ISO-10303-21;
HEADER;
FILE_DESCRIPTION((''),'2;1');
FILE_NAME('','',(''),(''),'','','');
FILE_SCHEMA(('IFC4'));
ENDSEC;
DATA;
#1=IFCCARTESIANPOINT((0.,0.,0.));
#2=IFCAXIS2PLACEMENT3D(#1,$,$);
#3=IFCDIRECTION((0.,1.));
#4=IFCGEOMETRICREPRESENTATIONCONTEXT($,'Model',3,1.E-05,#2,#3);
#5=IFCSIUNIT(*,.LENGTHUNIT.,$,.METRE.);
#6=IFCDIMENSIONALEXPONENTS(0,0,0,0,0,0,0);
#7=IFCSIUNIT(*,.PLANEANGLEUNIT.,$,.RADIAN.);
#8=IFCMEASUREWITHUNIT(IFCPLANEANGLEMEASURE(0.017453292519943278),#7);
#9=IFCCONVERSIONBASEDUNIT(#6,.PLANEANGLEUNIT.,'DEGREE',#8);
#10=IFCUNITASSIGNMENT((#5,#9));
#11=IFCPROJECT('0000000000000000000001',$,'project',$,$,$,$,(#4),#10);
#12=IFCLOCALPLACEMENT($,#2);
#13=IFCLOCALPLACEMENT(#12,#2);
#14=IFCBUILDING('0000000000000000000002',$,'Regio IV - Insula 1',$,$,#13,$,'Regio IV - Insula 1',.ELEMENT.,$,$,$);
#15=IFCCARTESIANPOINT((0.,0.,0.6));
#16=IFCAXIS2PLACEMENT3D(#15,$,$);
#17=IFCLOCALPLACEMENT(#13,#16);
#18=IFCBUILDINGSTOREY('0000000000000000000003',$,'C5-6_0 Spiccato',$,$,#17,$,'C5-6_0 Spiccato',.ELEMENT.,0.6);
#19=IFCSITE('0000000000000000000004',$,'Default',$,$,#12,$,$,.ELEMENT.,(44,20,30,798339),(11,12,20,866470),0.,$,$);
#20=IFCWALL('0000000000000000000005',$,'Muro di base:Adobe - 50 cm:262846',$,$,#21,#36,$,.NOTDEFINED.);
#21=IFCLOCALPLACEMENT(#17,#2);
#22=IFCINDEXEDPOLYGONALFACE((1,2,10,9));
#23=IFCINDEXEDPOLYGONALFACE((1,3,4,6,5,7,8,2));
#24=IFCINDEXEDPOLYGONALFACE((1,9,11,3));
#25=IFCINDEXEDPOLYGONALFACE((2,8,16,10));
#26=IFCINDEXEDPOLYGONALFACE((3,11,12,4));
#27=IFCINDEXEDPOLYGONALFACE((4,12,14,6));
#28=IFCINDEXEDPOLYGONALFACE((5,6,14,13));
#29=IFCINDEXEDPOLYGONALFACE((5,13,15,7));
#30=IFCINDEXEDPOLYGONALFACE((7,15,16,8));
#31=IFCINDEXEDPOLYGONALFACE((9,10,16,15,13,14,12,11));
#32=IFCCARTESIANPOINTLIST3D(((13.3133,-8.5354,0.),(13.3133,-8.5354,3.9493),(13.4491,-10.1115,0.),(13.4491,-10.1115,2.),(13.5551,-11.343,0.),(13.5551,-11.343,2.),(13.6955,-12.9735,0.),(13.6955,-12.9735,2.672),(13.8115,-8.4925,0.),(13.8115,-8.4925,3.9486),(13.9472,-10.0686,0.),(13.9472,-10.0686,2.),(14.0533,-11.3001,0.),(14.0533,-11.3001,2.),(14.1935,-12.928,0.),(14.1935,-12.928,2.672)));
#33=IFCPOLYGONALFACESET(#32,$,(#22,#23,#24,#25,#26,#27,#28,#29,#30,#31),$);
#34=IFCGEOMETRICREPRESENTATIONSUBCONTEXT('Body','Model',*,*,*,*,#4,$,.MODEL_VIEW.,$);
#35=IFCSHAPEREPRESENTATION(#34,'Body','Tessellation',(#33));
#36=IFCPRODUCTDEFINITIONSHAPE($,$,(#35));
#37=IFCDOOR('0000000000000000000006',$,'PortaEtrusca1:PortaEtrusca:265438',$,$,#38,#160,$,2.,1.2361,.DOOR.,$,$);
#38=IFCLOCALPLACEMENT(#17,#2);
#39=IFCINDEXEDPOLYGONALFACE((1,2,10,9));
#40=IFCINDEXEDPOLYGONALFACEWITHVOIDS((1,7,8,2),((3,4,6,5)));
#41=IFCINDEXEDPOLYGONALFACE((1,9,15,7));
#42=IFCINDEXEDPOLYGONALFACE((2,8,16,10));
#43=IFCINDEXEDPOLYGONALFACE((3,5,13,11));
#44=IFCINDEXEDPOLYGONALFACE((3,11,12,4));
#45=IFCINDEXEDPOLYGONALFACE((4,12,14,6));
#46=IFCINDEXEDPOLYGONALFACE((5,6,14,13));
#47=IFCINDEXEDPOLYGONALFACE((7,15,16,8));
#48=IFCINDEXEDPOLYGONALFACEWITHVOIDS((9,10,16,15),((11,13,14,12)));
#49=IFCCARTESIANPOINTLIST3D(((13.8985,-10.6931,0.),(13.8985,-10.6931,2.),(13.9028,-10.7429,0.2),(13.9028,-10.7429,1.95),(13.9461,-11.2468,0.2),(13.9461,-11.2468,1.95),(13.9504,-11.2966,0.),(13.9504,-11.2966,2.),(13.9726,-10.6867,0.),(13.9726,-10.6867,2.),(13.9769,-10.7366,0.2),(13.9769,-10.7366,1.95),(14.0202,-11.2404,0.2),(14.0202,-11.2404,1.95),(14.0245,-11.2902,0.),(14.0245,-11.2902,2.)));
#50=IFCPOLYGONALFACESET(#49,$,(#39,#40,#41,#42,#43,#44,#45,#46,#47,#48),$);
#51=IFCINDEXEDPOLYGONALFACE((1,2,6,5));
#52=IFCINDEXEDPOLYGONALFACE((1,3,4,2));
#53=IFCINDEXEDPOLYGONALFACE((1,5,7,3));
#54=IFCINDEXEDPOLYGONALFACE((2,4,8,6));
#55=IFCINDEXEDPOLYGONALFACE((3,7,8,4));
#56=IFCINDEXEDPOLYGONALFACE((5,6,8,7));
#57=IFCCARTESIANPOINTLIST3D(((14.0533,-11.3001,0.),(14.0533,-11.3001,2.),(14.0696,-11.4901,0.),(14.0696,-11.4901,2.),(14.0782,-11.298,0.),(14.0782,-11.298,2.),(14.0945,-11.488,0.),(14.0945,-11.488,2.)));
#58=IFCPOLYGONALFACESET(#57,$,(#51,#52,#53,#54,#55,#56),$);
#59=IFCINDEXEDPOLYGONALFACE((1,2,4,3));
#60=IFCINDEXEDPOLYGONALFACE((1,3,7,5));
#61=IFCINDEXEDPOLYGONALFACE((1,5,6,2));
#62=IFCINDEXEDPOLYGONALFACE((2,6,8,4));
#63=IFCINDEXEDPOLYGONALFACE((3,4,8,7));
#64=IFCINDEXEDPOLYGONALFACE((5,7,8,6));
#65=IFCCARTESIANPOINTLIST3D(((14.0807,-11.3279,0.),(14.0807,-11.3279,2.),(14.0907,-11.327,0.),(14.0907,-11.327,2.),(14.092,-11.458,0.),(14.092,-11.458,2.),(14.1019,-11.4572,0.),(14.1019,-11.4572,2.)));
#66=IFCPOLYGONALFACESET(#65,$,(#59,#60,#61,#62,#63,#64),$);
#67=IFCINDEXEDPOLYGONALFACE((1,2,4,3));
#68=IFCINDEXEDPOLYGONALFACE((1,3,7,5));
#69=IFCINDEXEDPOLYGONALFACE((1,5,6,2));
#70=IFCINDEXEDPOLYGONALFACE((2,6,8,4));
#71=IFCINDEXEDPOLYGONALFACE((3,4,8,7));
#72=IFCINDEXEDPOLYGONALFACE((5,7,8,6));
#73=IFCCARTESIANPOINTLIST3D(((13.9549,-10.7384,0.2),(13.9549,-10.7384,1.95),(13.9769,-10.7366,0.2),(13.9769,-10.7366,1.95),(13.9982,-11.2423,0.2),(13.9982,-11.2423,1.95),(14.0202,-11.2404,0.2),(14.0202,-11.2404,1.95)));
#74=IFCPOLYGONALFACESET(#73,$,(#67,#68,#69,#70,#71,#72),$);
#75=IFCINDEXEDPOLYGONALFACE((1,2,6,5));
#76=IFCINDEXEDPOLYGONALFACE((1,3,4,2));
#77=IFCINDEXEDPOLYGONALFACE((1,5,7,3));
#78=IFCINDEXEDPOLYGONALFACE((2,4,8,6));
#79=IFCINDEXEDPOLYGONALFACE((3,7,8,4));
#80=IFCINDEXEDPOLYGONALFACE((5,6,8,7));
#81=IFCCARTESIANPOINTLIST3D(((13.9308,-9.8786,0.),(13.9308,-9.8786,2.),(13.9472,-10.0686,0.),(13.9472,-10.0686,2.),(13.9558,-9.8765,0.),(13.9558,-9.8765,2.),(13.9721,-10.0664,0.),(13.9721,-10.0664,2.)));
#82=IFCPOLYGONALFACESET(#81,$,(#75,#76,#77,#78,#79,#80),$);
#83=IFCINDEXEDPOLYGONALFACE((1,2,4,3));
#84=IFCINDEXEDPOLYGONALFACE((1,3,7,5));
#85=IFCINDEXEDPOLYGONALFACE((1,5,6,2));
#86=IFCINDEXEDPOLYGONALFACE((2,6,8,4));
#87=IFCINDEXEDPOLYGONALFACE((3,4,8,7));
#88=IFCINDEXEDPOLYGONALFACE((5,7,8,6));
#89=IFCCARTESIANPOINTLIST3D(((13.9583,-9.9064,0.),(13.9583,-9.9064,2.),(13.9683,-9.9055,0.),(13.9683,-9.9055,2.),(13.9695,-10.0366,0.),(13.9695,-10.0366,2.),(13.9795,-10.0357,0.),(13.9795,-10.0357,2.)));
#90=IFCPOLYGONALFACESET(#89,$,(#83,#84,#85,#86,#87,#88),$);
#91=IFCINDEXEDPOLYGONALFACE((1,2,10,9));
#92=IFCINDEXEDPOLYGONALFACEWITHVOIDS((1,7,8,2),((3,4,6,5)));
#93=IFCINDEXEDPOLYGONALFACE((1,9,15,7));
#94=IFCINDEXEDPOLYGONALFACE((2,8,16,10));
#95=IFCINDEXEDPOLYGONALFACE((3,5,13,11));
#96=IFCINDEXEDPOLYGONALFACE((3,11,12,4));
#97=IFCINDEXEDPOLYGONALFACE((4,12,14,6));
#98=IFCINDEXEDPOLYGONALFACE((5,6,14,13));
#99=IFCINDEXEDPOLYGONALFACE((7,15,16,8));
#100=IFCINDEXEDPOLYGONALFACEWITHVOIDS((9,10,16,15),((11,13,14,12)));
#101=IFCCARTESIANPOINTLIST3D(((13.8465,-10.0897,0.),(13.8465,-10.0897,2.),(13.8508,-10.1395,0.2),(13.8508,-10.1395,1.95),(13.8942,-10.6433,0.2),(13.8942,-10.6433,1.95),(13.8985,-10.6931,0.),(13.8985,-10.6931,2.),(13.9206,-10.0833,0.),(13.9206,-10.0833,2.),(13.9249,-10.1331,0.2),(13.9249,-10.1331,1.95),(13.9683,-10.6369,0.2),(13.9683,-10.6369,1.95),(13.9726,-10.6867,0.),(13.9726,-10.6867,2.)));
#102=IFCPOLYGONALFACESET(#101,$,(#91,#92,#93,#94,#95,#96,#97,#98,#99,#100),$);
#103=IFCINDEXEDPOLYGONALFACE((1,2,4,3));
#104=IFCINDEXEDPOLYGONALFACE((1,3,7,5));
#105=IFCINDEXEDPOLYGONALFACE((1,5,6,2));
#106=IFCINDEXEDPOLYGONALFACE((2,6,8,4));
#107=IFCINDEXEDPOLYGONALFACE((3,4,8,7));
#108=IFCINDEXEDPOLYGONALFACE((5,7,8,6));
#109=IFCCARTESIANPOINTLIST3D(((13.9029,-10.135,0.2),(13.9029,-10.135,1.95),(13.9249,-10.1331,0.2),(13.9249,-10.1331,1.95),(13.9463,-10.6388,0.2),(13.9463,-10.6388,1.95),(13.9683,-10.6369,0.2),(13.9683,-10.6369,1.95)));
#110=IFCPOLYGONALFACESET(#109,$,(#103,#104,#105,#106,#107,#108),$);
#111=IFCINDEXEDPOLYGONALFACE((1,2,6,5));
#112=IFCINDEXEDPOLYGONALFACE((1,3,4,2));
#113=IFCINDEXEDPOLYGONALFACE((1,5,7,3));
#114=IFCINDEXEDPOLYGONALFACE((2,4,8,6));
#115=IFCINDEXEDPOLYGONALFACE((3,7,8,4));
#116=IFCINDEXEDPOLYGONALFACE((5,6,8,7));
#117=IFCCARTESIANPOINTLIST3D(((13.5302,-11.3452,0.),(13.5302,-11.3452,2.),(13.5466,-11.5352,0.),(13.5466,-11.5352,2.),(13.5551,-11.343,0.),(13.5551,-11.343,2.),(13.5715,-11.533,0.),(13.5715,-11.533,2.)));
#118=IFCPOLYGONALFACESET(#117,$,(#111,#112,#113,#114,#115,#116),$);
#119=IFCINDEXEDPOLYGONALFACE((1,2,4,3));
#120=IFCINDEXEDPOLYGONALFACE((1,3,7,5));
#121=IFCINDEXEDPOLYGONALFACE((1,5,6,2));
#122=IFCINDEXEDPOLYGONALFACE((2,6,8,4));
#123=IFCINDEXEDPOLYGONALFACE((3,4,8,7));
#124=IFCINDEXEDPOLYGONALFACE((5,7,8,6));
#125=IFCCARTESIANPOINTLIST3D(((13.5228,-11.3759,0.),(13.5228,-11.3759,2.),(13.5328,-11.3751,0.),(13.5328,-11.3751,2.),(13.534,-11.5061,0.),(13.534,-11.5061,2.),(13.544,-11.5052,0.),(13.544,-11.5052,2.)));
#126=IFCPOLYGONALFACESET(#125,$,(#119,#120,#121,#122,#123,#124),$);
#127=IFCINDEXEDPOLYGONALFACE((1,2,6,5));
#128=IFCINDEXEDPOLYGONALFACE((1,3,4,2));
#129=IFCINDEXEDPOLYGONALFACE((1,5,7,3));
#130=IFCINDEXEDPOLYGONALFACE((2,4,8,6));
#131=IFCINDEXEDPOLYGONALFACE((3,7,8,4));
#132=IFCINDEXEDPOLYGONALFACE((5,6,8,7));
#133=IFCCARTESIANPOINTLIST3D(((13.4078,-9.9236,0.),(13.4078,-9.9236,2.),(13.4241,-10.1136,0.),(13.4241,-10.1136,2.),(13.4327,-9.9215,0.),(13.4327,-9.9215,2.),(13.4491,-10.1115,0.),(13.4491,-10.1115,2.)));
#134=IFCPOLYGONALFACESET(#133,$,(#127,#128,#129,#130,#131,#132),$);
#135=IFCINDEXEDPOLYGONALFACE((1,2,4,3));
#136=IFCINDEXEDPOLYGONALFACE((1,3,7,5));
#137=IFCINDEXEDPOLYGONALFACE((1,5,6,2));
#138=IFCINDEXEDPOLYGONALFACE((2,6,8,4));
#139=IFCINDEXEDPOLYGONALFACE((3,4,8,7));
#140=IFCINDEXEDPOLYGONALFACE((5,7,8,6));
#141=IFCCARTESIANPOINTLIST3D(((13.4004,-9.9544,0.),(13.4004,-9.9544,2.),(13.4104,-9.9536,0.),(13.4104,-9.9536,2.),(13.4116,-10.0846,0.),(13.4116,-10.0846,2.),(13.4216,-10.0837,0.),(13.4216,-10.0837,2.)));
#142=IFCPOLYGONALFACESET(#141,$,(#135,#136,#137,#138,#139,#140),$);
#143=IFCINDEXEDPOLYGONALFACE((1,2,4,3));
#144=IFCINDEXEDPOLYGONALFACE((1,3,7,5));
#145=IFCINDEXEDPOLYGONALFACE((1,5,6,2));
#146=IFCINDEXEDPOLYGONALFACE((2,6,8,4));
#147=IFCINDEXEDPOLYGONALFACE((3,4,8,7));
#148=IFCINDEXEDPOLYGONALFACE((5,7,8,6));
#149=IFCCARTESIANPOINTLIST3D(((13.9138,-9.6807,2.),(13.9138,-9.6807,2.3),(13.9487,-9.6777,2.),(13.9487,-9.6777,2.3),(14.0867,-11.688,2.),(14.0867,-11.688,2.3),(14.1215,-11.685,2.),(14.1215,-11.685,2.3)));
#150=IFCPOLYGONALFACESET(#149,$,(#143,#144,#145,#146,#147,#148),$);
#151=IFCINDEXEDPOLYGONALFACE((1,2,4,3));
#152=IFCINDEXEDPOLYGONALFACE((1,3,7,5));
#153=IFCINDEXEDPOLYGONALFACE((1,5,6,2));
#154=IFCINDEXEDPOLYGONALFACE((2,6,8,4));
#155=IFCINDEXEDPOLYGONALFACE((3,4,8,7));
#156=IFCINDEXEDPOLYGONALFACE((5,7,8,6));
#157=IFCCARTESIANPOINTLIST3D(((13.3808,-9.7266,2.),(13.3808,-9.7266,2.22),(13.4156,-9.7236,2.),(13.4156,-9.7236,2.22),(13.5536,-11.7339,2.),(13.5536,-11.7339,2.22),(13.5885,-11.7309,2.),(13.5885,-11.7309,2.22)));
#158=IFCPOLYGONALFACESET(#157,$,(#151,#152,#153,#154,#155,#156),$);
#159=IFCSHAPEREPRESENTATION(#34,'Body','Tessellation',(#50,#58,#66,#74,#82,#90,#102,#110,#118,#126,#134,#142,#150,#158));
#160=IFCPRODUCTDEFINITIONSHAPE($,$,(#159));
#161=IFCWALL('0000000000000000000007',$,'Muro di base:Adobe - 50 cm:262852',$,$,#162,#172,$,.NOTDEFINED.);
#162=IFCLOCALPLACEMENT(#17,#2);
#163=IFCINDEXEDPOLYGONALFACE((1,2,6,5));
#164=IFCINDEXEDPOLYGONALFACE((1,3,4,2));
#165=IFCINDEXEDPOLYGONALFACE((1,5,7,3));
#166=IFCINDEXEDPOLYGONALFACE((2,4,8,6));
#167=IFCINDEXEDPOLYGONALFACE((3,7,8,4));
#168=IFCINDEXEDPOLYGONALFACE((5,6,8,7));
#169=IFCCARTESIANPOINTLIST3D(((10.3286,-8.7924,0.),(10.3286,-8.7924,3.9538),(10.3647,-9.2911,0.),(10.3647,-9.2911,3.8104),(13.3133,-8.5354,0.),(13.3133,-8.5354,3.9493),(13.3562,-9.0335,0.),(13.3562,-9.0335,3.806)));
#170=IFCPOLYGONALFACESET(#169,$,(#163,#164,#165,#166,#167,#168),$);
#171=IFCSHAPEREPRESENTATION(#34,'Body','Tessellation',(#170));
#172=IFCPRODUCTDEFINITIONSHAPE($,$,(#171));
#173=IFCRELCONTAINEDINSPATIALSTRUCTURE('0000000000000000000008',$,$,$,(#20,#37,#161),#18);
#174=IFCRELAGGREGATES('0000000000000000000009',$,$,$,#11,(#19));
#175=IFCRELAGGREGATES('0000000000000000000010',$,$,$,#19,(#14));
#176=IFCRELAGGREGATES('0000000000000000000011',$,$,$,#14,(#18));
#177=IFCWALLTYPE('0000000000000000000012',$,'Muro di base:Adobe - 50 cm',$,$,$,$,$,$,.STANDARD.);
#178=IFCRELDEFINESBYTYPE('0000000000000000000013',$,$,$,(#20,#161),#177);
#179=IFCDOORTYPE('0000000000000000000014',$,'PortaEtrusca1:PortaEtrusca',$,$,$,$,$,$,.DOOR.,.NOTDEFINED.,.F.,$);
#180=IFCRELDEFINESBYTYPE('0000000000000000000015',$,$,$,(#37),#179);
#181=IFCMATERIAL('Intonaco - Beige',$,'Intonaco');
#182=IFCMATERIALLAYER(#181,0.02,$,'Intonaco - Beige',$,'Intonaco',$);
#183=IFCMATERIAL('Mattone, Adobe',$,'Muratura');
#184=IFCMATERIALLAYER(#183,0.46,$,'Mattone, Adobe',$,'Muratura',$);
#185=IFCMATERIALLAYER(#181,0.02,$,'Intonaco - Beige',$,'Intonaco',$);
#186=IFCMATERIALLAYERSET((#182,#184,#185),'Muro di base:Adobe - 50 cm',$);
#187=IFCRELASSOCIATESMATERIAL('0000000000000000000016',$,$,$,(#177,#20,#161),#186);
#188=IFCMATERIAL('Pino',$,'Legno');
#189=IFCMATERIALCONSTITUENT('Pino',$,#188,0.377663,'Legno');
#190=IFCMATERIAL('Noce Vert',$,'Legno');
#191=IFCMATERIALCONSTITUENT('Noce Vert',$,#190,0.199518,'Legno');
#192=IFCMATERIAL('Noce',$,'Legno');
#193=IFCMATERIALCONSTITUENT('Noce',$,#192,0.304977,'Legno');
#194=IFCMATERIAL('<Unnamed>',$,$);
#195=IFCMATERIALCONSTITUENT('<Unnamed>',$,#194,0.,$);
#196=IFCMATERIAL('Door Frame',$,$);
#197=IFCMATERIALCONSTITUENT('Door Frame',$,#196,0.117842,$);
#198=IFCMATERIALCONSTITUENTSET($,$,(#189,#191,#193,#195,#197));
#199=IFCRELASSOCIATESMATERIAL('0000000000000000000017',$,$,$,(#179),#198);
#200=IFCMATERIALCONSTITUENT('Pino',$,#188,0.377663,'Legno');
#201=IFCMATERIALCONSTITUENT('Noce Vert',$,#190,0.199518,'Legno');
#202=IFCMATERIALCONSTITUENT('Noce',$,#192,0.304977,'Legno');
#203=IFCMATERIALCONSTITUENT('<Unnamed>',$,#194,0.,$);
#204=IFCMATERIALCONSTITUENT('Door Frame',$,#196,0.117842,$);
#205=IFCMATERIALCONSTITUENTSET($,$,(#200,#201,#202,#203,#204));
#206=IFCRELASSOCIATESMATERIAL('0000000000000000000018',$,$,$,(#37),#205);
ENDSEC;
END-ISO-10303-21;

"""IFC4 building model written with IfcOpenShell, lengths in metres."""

from ifc_helpers import new_model, entity, si_unit, converted_unit, direction, frame, frame_2d, origin, origin_2d_with_axis, place, context, subcontext, project, spatial, polyline, rectangle, outline, extrude, clip, bounded_halfspace, source, transform, mapped, material, layer, layer_set, layer_usage, constituent, constituent_set, type_object, type_shapes, element, fill, save


model = new_model("IFC4")

# Units and contexts
model_context = context("Model", 3, precision=1e-05, world=origin(), true_north=direction((0.0, 1.0)))
body_context = subcontext(model_context, "Body", "Model", "MODEL_VIEW")
ifc_project = project(units=[si_unit("LENGTHUNIT", "METRE"), converted_unit("PLANEANGLEUNIT", "DEGREE", entity("IfcPlaneAngleMeasure", 0.017453292519943278), si_unit("PLANEANGLEUNIT", "RADIAN"), dimensions=[0, 0, 0, 0, 0, 0, 0])], contexts=[model_context])

# Site, building, storey
site_placement = place(None, origin())
site = spatial("IfcSite", under=ifc_project, at=site_placement, Name="Default", CompositionType="ELEMENT", RefLatitude=(44, 20, 30, 798339), RefLongitude=(11, 12, 20, 866470), RefElevation=0.0)
building_placement = place(site_placement, origin())
building = spatial("IfcBuilding", under=site, at=building_placement, Name="Regio IV - Insula 1", LongName="Regio IV - Insula 1", CompositionType="ELEMENT")
storey_placement = place(building_placement, frame((0.0, 0.0, 0.6)))
storey = spatial("IfcBuildingStorey", under=building, at=storey_placement, Name="C5-6_0 Spiccato", LongName="C5-6_0 Spiccato", CompositionType="ELEMENT", Elevation=0.6)

# Shared definitions
ifc_material_1 = material(Name="Intonaco - Beige", Category="Intonaco")
ifc_material_2 = material(Name="Mattone, Adobe", Category="Muratura")
ifc_layer_1 = layer(ifc_material_1, 0.02, Name="Intonaco - Beige", Category="Intonaco")
ifc_layer_2 = layer(ifc_material_2, 0.46, Name="Mattone, Adobe", Category="Muratura")
ifc_layer_3 = layer(ifc_material_1, 0.02, Name="Intonaco - Beige", Category="Intonaco")
ifc_layer_set_1 = layer_set([ifc_layer_1, ifc_layer_2, ifc_layer_3], Name="Muro di base:Adobe - 50 cm")
wall_type_1 = type_object("IfcWallType", Name="Muro di base:Adobe - 50 cm", PredefinedType="STANDARD", material=ifc_layer_set_1)

# Shared definitions
ifc_material_3 = material(Name="Pino", Category="Legno")
ifc_material_4 = material(Name="Noce Vert", Category="Legno")
ifc_material_5 = material(Name="Noce", Category="Legno")
ifc_material_6 = material(Name="<Unnamed>")
ifc_material_7 = material(Name="Door Frame")
ifc_constituent_1 = constituent(ifc_material_3, Name="Pino", Category="Legno", fraction=0.377663)
ifc_constituent_2 = constituent(ifc_material_4, Name="Noce Vert", Category="Legno", fraction=0.199518)
ifc_constituent_3 = constituent(ifc_material_5, Name="Noce", Category="Legno", fraction=0.304977)
ifc_constituent_4 = constituent(ifc_material_6, Name="<Unnamed>", fraction=0.0)
ifc_constituent_5 = constituent(ifc_material_7, Name="Door Frame", fraction=0.117842)
ifc_constituent_set_1 = constituent_set(constituents=[ifc_constituent_1, ifc_constituent_2, ifc_constituent_3, ifc_constituent_4, ifc_constituent_5])
door_type = type_object("IfcDoorType", Name="PortaEtrusca1:PortaEtrusca", OperationType="NOTDEFINED", ParameterTakesPrecedence=False, PredefinedType="DOOR", material=ifc_constituent_set_1)
shared_shape = source(origin(), body_context, "Body", "SweptSolid", [
    extrude(outline(polyline([(-1.0, -0.3028), (1.0, -0.3028), (1.0, 0.3028), (-1.0, 0.3028), (-1.0, -0.3028)]), holes=[polyline([(-0.95, 0.2528), (0.8, 0.2528), (0.8, -0.2528), (-0.95, -0.2528), (-0.95, 0.2528)])]), frame((0.3152, 0.0278, 1.0), z_axis=(0.0, 1.0, 0.0), x_axis=(0.0, 0.0, -1.0)), (0.0, 0.0, 1.0), 0.0744),
    extrude(rectangle(XDim=0.025, YDim=0.1907, at=frame_2d((0.0, 0.0), x_axis=(1.0, 0.0))), frame((-0.0953, -0.0125, 0.0), z_axis=(0.0, 0.0, 1.0), x_axis=(0.0, 1.0, 0.0)), (0.0, 0.0, 1.0), 2.0),
    extrude(rectangle(XDim=0.01, YDim=0.1306, at=frame_2d((0.0, 0.0), x_axis=(1.0, 0.0))), frame((-0.0953, -0.03, 0.0), z_axis=(0.0, 0.0, 1.0), x_axis=(0.0, 1.0, 0.0)), (0.0, 0.0, 1.0), 2.0),
    extrude(rectangle(XDim=0.0221, YDim=0.5057, at=frame_2d((0.0, 0.0), x_axis=(1.0, 0.0))), frame((0.3152, 0.0388, 0.2), z_axis=(0.0, 0.0, 1.0), x_axis=(0.0, 1.0, 0.0)), (0.0, 0.0, 1.0), 1.75),
    extrude(rectangle(XDim=0.025, YDim=0.1907, at=frame_2d((0.0, 0.0), x_axis=(1.0, 0.0))), frame((1.3314, -0.0125, 0.0), z_axis=(0.0, 0.0, 1.0), x_axis=(0.0, 1.0, 0.0)), (0.0, 0.0, 1.0), 2.0),
    extrude(rectangle(XDim=0.01, YDim=0.1306, at=frame_2d((0.0, 0.0), x_axis=(1.0, 0.0))), frame((1.3314, -0.03, 0.0), z_axis=(0.0, 0.0, 1.0), x_axis=(0.0, 1.0, 0.0)), (0.0, 0.0, 1.0), 2.0),
    extrude(outline(polyline([(-0.3028, -1.0), (0.3028, -1.0), (0.3028, 1.0), (-0.3028, 1.0), (-0.3028, -1.0)]), holes=[polyline([(0.2528, -0.95), (-0.2528, -0.95), (-0.2528, 0.8), (0.2528, 0.8), (0.2528, -0.95)])]), frame((0.9209, 0.0278, 1.0), z_axis=(0.0, 1.0, 0.0), x_axis=(1.0, 0.0, 0.0)), (0.0, 0.0, 1.0), 0.0744),
    extrude(rectangle(XDim=0.0221, YDim=0.5057, at=frame_2d((0.0, 0.0), x_axis=(1.0, 0.0))), frame((0.9209, 0.0388, 0.2), z_axis=(0.0, 0.0, 1.0), x_axis=(0.0, 1.0, 0.0)), (0.0, 0.0, 1.0), 1.75),
    extrude(rectangle(XDim=0.025, YDim=0.1907, at=frame_2d((0.0, 0.0), x_axis=(1.0, 0.0))), frame((-0.0953, 0.5125, 0.0), z_axis=(0.0, 0.0, 1.0), x_axis=(0.0, -1.0, 0.0)), (0.0, 0.0, 1.0), 2.0),
    extrude(rectangle(XDim=0.01, YDim=0.1306, at=frame_2d((0.0, 0.0), x_axis=(1.0, 0.0))), frame((-0.0953, 0.53, 0.0), z_axis=(0.0, 0.0, 1.0), x_axis=(0.0, -1.0, 0.0)), (0.0, 0.0, 1.0), 2.0),
    extrude(rectangle(XDim=0.025, YDim=0.1907, at=frame_2d((0.0, 0.0), x_axis=(1.0, 0.0))), frame((1.3314, 0.5125, 0.0), z_axis=(0.0, 0.0, 1.0), x_axis=(0.0, -1.0, 0.0)), (0.0, 0.0, 1.0), 2.0),
    extrude(rectangle(XDim=0.01, YDim=0.1306, at=frame_2d((0.0, 0.0), x_axis=(1.0, 0.0))), frame((1.3314, 0.53, 0.0), z_axis=(0.0, 0.0, 1.0), x_axis=(0.0, -1.0, 0.0)), (0.0, 0.0, 1.0), 2.0),
    extrude(rectangle(XDim=0.035, YDim=2.0147, at=origin_2d_with_axis()), frame((0.618, -0.0175, 2.0), z_axis=(0.0, 0.0, 1.0), x_axis=(0.0, 1.0, 0.0)), (0.0, 0.0, 1.0), 0.3),
    extrude(rectangle(XDim=0.035, YDim=2.0147, at=origin_2d_with_axis()), frame((0.618, 0.5175, 2.0), z_axis=(0.0, 0.0, 1.0), x_axis=(0.0, -1.0, 0.0)), (0.0, 0.0, 1.0), 0.22),
])
type_shapes(door_type, [shared_shape])

# Wall, opening, door
ifc_layer_usage_1 = layer_usage(ifc_layer_set_1, "AXIS2", "NEGATIVE", 0.25)
wall_1_placement = place(storey_placement, frame((13.9446, -12.952, 0.0), z_axis=(0.0, 0.0, 1.0), x_axis=(-0.085801, 0.996312, 0.0)))
wall_1 = element("IfcWall", 1, at=wall_1_placement, inside=storey, type_object=wall_type_1, material=ifc_layer_usage_1, Name="Muro di base:Adobe - 50 cm:262846", PredefinedType="NOTDEFINED", context=body_context, shape_type="Clipping", body=[
    clip(extrude(outline(polyline([(0.0026, -0.25), (4.4545, -0.25), (4.4545, 0.25), (3.9545, 0.25), (0.0, 0.25), (0.0026, -0.25)])), origin(), (0.0, 0.0, 1.0), 3.9493), bounded_halfspace(frame((0.0026, -0.25, 2.672), z_axis=(-0.275634, -0.001422, 0.961262), x_axis=(0.00516, -0.999987, 0.0)), False, frame((0.0026, -0.25, 2.672)), polyline([(0.0, 0.0), (4.452, 0.0), (4.452, 0.5), (3.952, 0.5), (-0.0026, 0.5), (0.0, 0.0)]))),
])
opening_1_placement = place(wall_1_placement, frame((1.6365, -0.25, 0.0)))
opening_1 = element("IfcOpeningElement", 2, at=opening_1_placement, cuts=wall_1, PredefinedType="OPENING", context=body_context, shape_type="SweptSolid", body=[
    extrude(rectangle(XDim=2.0, YDim=1.2361, at=frame_2d((1.0, 0.618), x_axis=(1.0, 0.0))), frame((0.0, 0.0, 0.0), z_axis=(0.0, 1.0, 0.0), x_axis=(0.0, 0.0, 1.0)), (0.0, 0.0, 1.0), 0.5),
])
ifc_constituent_6 = constituent(ifc_material_3, Name="Pino", Category="Legno", fraction=0.377663)
ifc_constituent_7 = constituent(ifc_material_4, Name="Noce Vert", Category="Legno", fraction=0.199518)
ifc_constituent_8 = constituent(ifc_material_5, Name="Noce", Category="Legno", fraction=0.304977)
ifc_constituent_9 = constituent(ifc_material_6, Name="<Unnamed>", fraction=0.0)
ifc_constituent_10 = constituent(ifc_material_7, Name="Door Frame", fraction=0.117842)
ifc_constituent_set_2 = constituent_set(constituents=[ifc_constituent_6, ifc_constituent_7, ifc_constituent_8, ifc_constituent_9, ifc_constituent_10])
door_1_placement = place(opening_1_placement, origin())
door_1 = element("IfcDoor", 3, at=door_1_placement, inside=storey, type_object=door_type, material=ifc_constituent_set_2, Name="PortaEtrusca1:PortaEtrusca:265438", OverallHeight=2.0, OverallWidth=1.2361, PredefinedType="DOOR", context=body_context, shape_type="MappedRepresentation", body=[
    mapped(shared_shape, transform((0.0, 0.0, 0.0), scale=1.0)),
])
fill(opening_1, door_1)

# Wall
ifc_layer_usage_2 = layer_usage(ifc_layer_set_1, "AXIS2", "NEGATIVE", 0.25)
wall_2_placement = place(storey_placement, frame((13.3348, -8.7844, 0.0), z_axis=(0.0, 0.0, 1.0), x_axis=(-0.996312, -0.085801, 0.0)))
element("IfcWall", 4, at=wall_2_placement, inside=storey, type_object=wall_type_1, material=ifc_layer_usage_2, Name="Muro di base:Adobe - 50 cm:262852", PredefinedType="NOTDEFINED", context=body_context, shape_type="Clipping", body=[
    clip(extrude(outline(polyline([(2.9957, -0.25), (3.0026, 0.25), (0.0, 0.25), (0.0, -0.25), (2.9957, -0.25)])), origin(), (0.0, 0.0, 1.0), 3.9538), bounded_halfspace(frame((0.0, -0.25, 3.9493), z_axis=(-0.001422, 0.275634, 0.961262), x_axis=(-0.999987, -0.00516, 0.0)), False, frame((0.0, -0.25, 3.9493)), polyline([(0.0, 0.0), (2.9957, 0.0), (3.0026, 0.5), (0.0, 0.5), (0.0, 0.0)]))),
])

save(model, "model.ifc")
